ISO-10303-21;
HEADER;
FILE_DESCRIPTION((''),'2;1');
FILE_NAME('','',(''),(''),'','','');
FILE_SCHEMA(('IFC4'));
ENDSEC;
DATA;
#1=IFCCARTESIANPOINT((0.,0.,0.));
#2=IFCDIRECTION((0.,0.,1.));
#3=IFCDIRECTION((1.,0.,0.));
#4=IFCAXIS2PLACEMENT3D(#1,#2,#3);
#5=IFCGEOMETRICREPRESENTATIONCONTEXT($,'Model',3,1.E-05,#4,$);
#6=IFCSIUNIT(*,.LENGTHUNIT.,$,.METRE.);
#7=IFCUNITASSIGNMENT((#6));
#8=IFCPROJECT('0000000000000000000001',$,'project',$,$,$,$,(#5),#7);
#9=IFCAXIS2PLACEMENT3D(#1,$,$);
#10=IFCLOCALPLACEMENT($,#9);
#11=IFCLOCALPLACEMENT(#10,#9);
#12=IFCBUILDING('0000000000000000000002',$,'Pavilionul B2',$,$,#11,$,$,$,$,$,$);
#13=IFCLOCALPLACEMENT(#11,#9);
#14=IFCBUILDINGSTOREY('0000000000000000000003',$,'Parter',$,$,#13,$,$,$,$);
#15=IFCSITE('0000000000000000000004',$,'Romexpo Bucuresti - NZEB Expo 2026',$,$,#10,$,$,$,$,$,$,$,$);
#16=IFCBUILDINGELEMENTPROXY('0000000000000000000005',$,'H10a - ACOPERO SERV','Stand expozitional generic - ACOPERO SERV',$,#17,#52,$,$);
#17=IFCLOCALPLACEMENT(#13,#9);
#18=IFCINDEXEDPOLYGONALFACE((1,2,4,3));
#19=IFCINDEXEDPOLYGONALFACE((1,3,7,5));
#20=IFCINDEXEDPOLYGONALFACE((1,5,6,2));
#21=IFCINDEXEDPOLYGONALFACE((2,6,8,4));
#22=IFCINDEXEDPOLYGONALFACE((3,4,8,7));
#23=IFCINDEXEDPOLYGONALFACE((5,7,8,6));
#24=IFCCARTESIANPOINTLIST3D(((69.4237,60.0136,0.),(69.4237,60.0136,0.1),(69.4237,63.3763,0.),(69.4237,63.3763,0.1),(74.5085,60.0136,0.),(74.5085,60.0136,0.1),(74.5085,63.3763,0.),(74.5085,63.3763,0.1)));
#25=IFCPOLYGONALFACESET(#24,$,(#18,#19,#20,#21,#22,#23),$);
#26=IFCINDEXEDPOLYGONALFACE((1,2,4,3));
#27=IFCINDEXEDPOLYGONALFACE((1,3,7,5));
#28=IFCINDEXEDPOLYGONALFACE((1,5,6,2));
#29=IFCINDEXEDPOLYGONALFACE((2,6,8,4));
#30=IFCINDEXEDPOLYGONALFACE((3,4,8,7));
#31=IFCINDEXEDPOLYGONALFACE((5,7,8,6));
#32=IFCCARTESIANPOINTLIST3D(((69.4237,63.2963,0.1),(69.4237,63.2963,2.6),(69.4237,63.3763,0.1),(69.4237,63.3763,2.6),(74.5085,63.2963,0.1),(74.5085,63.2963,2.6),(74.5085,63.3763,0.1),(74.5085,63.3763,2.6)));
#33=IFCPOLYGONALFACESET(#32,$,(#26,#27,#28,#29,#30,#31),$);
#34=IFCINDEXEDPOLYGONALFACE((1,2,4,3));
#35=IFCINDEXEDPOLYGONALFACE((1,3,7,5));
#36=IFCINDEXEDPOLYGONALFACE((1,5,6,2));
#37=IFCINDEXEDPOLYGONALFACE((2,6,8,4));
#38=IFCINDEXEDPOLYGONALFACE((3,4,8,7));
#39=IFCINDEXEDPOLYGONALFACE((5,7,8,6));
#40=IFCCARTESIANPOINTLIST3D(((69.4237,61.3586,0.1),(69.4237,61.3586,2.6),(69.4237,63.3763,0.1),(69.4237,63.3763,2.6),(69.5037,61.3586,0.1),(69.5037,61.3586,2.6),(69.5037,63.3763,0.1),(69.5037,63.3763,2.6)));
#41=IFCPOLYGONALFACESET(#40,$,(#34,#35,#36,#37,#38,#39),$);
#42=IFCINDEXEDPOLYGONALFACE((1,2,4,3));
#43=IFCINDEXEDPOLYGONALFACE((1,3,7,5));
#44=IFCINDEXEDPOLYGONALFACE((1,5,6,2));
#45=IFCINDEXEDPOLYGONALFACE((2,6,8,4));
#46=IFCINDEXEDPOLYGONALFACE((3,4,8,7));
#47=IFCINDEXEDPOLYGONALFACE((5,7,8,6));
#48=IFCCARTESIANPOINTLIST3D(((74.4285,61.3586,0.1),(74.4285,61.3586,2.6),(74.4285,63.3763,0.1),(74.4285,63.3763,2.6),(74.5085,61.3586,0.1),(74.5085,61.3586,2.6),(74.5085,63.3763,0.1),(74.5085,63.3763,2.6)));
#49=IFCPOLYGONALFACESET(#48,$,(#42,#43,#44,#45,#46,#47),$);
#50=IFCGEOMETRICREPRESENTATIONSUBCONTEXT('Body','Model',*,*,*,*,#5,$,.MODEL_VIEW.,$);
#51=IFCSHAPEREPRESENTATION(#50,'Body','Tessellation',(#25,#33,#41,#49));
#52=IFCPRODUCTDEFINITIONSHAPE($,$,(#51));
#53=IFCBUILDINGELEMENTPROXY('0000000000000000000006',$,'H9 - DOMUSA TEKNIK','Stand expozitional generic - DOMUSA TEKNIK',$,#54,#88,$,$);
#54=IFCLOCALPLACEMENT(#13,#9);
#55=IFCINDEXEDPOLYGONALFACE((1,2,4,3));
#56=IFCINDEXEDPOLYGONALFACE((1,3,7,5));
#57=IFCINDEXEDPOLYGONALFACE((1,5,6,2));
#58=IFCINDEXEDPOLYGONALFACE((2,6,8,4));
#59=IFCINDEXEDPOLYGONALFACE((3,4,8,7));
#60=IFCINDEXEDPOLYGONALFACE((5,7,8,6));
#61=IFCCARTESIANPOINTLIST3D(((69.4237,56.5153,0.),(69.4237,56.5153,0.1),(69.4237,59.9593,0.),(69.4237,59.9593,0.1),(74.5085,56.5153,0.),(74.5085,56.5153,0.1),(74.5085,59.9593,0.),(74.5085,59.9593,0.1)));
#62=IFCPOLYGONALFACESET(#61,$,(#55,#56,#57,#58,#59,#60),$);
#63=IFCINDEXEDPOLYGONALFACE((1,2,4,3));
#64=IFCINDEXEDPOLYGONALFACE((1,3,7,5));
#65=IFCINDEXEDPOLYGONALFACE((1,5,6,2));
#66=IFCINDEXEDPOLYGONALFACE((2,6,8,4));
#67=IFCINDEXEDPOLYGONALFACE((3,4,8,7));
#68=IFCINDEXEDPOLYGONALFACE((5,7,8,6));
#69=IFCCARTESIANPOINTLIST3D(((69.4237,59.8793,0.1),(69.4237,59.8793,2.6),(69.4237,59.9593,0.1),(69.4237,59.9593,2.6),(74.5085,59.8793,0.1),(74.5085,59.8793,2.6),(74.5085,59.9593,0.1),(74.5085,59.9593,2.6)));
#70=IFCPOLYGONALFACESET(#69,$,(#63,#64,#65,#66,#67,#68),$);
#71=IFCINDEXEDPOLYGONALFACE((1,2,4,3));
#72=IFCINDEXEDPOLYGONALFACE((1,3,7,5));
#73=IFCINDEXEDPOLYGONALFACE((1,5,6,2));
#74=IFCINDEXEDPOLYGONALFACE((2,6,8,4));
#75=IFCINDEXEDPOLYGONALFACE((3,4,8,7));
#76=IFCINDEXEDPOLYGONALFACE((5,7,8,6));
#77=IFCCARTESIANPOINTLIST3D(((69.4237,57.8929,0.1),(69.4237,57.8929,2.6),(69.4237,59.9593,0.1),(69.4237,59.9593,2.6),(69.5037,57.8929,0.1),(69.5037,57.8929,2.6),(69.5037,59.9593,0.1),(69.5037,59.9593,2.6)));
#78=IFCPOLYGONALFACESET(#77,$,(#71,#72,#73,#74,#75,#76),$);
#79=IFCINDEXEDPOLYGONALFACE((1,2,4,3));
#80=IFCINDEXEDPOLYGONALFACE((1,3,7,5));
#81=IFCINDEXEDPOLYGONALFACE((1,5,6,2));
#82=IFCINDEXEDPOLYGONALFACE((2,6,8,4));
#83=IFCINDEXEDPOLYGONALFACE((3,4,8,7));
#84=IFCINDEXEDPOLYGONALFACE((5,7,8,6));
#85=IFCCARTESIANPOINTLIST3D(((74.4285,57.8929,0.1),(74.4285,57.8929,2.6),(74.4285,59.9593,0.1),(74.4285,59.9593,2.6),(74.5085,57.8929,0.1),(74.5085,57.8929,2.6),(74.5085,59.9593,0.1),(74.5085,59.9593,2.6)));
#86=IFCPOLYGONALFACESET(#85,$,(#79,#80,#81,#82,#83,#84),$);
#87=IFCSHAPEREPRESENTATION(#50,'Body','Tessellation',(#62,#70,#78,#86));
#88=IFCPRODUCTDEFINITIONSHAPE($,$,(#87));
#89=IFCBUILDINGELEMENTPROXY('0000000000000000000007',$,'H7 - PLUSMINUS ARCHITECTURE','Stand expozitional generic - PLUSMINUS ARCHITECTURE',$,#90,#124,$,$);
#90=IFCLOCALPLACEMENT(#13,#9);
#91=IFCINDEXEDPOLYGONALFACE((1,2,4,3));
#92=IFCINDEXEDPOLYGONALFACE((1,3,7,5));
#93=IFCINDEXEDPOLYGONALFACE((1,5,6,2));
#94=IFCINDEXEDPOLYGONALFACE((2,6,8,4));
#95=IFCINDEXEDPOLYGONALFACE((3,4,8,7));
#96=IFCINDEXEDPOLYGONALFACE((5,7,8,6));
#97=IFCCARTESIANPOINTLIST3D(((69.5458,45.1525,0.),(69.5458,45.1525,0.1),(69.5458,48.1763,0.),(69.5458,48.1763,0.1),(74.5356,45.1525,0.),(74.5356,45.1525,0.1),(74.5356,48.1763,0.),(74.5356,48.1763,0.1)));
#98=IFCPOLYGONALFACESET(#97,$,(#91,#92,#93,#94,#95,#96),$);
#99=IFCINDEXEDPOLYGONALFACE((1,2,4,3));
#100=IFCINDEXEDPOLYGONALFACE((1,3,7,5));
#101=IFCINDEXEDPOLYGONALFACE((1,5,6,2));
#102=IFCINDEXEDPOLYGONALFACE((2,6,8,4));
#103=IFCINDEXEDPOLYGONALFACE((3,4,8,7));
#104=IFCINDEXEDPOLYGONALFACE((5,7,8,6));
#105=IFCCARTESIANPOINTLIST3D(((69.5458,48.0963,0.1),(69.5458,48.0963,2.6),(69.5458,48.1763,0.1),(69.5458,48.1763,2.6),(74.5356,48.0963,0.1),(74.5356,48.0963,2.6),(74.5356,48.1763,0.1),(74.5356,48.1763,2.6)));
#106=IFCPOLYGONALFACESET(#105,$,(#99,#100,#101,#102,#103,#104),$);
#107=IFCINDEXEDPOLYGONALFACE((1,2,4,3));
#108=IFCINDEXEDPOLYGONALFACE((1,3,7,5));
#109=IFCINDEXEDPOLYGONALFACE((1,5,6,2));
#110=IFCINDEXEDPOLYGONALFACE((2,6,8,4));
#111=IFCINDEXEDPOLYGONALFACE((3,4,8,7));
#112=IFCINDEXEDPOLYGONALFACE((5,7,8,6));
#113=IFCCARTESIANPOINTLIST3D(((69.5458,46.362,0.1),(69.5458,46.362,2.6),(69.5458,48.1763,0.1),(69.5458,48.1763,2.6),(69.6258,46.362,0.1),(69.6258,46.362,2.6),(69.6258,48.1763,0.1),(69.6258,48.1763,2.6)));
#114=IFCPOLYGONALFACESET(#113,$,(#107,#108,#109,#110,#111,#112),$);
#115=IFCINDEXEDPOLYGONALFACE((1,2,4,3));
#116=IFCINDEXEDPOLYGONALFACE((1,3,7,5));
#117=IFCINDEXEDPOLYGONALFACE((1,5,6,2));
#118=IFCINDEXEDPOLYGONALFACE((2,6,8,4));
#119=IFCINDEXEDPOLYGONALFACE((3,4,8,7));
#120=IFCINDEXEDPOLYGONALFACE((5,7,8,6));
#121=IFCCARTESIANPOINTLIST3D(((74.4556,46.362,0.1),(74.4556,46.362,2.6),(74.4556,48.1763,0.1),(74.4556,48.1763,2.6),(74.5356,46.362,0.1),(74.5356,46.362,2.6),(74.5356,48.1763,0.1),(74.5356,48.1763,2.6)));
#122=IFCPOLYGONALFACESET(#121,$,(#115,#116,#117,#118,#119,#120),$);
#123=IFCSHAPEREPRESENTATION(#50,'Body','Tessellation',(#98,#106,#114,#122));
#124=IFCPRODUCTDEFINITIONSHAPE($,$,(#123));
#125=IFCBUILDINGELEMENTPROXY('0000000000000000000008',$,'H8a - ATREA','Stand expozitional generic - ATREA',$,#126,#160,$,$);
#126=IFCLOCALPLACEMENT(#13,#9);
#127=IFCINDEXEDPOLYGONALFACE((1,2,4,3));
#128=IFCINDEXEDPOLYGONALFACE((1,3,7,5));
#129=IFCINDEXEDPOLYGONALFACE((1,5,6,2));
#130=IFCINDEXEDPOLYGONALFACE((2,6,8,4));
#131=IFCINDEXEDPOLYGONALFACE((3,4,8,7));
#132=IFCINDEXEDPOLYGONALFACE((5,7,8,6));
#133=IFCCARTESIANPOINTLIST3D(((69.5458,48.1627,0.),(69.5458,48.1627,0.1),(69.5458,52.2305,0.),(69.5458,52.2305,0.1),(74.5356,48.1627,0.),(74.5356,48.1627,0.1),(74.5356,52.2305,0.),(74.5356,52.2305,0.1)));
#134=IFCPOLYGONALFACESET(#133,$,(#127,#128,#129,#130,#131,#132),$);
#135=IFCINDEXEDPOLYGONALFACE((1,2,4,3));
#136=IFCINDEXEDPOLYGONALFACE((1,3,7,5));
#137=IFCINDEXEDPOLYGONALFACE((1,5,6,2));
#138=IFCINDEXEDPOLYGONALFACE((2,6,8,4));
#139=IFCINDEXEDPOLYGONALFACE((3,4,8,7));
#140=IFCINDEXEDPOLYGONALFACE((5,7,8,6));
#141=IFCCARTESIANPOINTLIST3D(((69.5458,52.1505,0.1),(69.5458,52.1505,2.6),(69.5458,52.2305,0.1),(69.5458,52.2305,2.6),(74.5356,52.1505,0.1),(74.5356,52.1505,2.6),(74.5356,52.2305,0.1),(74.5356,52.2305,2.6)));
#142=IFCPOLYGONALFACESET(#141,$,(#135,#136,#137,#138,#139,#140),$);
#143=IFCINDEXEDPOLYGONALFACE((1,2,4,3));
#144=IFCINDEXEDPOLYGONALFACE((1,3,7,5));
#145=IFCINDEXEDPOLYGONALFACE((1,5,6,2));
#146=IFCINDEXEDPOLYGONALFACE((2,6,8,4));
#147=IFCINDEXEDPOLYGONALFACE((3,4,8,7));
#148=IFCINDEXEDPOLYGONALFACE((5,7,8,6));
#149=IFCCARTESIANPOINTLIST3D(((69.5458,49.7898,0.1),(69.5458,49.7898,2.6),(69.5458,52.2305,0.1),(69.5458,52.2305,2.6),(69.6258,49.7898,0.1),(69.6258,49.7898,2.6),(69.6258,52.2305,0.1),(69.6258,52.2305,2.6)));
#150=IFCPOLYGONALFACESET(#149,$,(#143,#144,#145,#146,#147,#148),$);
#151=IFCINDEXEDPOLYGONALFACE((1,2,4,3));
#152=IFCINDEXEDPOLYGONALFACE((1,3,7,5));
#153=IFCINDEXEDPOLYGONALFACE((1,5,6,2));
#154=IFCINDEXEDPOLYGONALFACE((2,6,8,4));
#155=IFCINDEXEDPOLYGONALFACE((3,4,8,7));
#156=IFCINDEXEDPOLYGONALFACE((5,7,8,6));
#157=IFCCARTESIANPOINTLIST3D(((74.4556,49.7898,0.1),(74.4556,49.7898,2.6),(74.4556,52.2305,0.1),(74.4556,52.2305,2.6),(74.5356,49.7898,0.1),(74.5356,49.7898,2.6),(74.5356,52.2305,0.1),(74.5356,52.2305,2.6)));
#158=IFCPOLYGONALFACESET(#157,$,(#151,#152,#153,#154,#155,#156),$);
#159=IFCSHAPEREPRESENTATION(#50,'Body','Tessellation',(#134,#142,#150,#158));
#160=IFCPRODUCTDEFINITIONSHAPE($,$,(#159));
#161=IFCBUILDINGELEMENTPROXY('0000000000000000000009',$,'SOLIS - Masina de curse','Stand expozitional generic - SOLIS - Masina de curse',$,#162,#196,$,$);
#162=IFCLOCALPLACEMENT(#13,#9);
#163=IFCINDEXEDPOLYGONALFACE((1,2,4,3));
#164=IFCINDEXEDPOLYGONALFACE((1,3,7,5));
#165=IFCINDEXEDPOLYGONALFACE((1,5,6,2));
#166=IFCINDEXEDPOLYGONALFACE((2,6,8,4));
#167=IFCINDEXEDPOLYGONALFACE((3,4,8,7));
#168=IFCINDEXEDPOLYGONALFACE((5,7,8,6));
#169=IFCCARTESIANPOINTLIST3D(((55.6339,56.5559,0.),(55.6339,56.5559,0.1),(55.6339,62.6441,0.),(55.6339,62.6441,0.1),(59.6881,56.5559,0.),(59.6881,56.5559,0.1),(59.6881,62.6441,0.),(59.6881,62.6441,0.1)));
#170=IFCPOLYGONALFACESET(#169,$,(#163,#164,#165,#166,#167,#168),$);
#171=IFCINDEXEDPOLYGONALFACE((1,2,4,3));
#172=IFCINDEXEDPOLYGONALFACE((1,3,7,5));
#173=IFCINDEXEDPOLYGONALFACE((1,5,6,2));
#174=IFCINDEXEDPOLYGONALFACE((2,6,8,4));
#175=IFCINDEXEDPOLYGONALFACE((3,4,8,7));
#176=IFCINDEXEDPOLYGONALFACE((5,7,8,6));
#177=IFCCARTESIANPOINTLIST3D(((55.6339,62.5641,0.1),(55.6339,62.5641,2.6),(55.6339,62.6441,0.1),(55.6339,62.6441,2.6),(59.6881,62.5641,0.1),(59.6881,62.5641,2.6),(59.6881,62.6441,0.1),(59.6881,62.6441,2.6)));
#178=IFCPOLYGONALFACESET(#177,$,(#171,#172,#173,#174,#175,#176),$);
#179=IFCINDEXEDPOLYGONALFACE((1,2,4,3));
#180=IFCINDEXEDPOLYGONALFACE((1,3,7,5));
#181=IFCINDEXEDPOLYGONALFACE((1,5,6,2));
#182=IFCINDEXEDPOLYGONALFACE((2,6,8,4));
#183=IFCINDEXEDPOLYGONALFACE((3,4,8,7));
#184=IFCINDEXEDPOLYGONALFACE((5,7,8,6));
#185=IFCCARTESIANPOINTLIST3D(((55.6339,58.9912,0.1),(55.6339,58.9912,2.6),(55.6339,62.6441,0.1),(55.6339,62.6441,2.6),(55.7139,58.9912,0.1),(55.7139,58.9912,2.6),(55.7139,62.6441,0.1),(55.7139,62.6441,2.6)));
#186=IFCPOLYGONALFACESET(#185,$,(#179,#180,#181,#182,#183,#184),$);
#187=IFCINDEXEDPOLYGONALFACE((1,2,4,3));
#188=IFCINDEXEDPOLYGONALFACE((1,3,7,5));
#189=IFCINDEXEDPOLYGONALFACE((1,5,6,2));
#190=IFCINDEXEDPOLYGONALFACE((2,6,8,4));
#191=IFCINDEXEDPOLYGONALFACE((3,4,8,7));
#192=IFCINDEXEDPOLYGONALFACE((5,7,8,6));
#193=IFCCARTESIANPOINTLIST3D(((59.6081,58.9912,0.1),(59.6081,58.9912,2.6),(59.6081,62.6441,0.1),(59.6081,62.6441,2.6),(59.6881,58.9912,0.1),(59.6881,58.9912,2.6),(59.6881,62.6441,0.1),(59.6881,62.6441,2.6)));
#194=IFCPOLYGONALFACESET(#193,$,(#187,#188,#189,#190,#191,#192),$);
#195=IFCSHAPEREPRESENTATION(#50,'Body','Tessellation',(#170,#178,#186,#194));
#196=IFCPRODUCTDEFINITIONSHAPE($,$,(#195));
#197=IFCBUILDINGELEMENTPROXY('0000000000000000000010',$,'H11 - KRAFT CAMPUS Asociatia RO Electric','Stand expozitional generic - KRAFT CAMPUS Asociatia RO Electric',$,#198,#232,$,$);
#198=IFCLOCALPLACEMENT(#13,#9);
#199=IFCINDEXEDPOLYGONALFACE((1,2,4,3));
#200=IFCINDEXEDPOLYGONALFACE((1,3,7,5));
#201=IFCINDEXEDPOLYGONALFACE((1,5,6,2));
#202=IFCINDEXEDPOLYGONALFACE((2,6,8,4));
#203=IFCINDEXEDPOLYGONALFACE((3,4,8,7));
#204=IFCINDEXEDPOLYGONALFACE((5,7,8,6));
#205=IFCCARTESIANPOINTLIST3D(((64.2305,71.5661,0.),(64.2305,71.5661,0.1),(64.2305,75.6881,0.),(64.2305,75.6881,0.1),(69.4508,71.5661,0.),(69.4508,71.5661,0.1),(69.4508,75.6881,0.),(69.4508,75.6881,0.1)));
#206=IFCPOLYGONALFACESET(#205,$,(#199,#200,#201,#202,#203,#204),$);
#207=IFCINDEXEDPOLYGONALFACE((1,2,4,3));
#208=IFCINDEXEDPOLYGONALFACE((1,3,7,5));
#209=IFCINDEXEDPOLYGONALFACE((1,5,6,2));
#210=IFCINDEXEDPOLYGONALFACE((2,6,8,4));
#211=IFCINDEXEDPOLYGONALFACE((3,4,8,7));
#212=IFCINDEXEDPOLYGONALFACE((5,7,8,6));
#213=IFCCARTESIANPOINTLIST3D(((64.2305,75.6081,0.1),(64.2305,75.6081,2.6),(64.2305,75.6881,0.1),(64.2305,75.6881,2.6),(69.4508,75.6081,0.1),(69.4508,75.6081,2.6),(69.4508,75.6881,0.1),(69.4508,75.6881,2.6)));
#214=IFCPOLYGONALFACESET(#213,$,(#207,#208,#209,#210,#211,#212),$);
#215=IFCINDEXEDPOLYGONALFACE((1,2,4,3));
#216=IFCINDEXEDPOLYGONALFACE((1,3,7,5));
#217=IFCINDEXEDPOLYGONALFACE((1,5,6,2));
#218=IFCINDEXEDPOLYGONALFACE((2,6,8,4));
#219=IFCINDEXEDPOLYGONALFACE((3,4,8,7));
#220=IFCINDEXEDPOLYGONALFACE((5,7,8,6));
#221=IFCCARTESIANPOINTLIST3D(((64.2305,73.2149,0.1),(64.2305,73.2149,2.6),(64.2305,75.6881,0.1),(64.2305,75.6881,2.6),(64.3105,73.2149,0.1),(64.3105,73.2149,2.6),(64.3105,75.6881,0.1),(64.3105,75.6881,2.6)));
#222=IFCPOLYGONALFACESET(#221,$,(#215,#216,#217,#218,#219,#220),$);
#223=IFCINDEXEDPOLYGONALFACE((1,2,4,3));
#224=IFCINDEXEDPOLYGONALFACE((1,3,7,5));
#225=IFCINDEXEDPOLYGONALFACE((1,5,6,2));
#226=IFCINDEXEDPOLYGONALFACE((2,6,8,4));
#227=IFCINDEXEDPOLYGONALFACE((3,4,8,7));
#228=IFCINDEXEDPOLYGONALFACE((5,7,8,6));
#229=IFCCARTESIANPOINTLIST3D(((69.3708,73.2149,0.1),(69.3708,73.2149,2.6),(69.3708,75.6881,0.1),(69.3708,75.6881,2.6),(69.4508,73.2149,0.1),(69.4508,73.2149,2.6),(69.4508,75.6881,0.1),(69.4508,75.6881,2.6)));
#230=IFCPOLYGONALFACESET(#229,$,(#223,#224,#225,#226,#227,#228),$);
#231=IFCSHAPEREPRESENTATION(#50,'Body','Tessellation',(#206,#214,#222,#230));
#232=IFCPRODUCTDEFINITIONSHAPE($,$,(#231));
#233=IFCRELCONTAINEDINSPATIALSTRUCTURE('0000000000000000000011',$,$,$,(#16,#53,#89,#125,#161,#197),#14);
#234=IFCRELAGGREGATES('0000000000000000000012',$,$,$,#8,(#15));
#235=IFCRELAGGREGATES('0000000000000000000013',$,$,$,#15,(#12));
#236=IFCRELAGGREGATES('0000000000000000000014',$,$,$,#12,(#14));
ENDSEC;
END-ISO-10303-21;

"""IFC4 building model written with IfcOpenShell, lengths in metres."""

from ifc_helpers import new_model, si_unit, frame, frame_2d, origin, origin_with_axes, place, context, subcontext, project, spatial, rectangle, extrude, element, save


model = new_model("IFC4")

# Units and contexts
model_context = context("Model", 3, precision=1e-05, world=origin_with_axes())
body_context = subcontext(model_context, "Body", "Model", "MODEL_VIEW")
ifc_project = project(units=[si_unit("LENGTHUNIT", "METRE")], contexts=[model_context])

# Site, building, storey
site_placement = place(None, origin())
site = spatial("IfcSite", under=ifc_project, at=site_placement, Name="Romexpo Bucuresti - NZEB Expo 2026")
building_placement = place(site_placement, origin())
building = spatial("IfcBuilding", under=site, at=building_placement, Name="Pavilionul B2")
storey_placement = place(building_placement, origin())
storey = spatial("IfcBuildingStorey", under=building, at=storey_placement, Name="Parter")

# Building element proxies
proxy_1_placement = place(storey_placement, frame((69.4237, 60.0136, 0.0), z_axis=(0.0, 0.0, 1.0), x_axis=(1.0, 0.0, 0.0)))
element("IfcBuildingElementProxy", 1, at=proxy_1_placement, inside=storey, Name="H10a - ACOPERO SERV", Description="Stand expozitional generic - ACOPERO SERV", context=body_context, shape_type="SweptSolid", body=[
    extrude(rectangle(XDim=5.0847, YDim=3.3627, at=frame_2d((2.5424, 1.6814))), origin(), (0.0, 0.0, 1.0), 0.1),
    extrude(rectangle(XDim=5.0847, YDim=0.08, at=frame_2d((2.5424, 3.3227))), frame((0.0, 0.0, 0.1)), (0.0, 0.0, 1.0), 2.5),
    extrude(rectangle(XDim=0.08, YDim=2.0176, at=frame_2d((0.04, 2.3539))), frame((0.0, 0.0, 0.1)), (0.0, 0.0, 1.0), 2.5),
    extrude(rectangle(XDim=0.08, YDim=2.0176, at=frame_2d((5.0447, 2.3539))), frame((0.0, 0.0, 0.1)), (0.0, 0.0, 1.0), 2.5),
])
proxy_2_placement = place(storey_placement, frame((69.4237, 56.5153, 0.0), z_axis=(0.0, 0.0, 1.0), x_axis=(1.0, 0.0, 0.0)))
element("IfcBuildingElementProxy", 2, at=proxy_2_placement, inside=storey, Name="H9 - DOMUSA TEKNIK", Description="Stand expozitional generic - DOMUSA TEKNIK", context=body_context, shape_type="SweptSolid", body=[
    extrude(rectangle(XDim=5.0847, YDim=3.4441, at=frame_2d((2.5424, 1.722))), origin(), (0.0, 0.0, 1.0), 0.1),
    extrude(rectangle(XDim=5.0847, YDim=0.08, at=frame_2d((2.5424, 3.4041))), frame((0.0, 0.0, 0.1)), (0.0, 0.0, 1.0), 2.5),
    extrude(rectangle(XDim=0.08, YDim=2.0664, at=frame_2d((0.04, 2.4108))), frame((0.0, 0.0, 0.1)), (0.0, 0.0, 1.0), 2.5),
    extrude(rectangle(XDim=0.08, YDim=2.0664, at=frame_2d((5.0447, 2.4108))), frame((0.0, 0.0, 0.1)), (0.0, 0.0, 1.0), 2.5),
])
proxy_3_placement = place(storey_placement, frame((69.5458, 45.1525, 0.0), z_axis=(0.0, 0.0, 1.0), x_axis=(1.0, 0.0, 0.0)))
element("IfcBuildingElementProxy", 3, at=proxy_3_placement, inside=storey, Name="H7 - PLUSMINUS ARCHITECTURE", Description="Stand expozitional generic - PLUSMINUS ARCHITECTURE", context=body_context, shape_type="SweptSolid", body=[
    extrude(rectangle(XDim=4.9898, YDim=3.0237, at=frame_2d((2.4949, 1.5119))), origin(), (0.0, 0.0, 1.0), 0.1),
    extrude(rectangle(XDim=4.9898, YDim=0.08, at=frame_2d((2.4949, 2.9837))), frame((0.0, 0.0, 0.1)), (0.0, 0.0, 1.0), 2.5),
    extrude(rectangle(XDim=0.08, YDim=1.8142, at=frame_2d((0.04, 2.1166))), frame((0.0, 0.0, 0.1)), (0.0, 0.0, 1.0), 2.5),
    extrude(rectangle(XDim=0.08, YDim=1.8142, at=frame_2d((4.9498, 2.1166))), frame((0.0, 0.0, 0.1)), (0.0, 0.0, 1.0), 2.5),
])
proxy_4_placement = place(storey_placement, frame((69.5458, 48.1627, 0.0), z_axis=(0.0, 0.0, 1.0), x_axis=(1.0, 0.0, 0.0)))
element("IfcBuildingElementProxy", 4, at=proxy_4_placement, inside=storey, Name="H8a - ATREA", Description="Stand expozitional generic - ATREA", context=body_context, shape_type="SweptSolid", body=[
    extrude(rectangle(XDim=4.9898, YDim=4.0678, at=frame_2d((2.4949, 2.0339))), origin(), (0.0, 0.0, 1.0), 0.1),
    extrude(rectangle(XDim=4.9898, YDim=0.08, at=frame_2d((2.4949, 4.0278))), frame((0.0, 0.0, 0.1)), (0.0, 0.0, 1.0), 2.5),
    extrude(rectangle(XDim=0.08, YDim=2.4407, at=frame_2d((0.04, 2.8475))), frame((0.0, 0.0, 0.1)), (0.0, 0.0, 1.0), 2.5),
    extrude(rectangle(XDim=0.08, YDim=2.4407, at=frame_2d((4.9498, 2.8475))), frame((0.0, 0.0, 0.1)), (0.0, 0.0, 1.0), 2.5),
])
proxy_5_placement = place(storey_placement, frame((55.6339, 56.5559, 0.0), z_axis=(0.0, 0.0, 1.0), x_axis=(1.0, 0.0, 0.0)))
element("IfcBuildingElementProxy", 5, at=proxy_5_placement, inside=storey, Name="SOLIS - Masina de curse", Description="Stand expozitional generic - SOLIS - Masina de curse", context=body_context, shape_type="SweptSolid", body=[
    extrude(rectangle(XDim=4.0542, YDim=6.0881, at=frame_2d((2.0271, 3.0441))), origin(), (0.0, 0.0, 1.0), 0.1),
    extrude(rectangle(XDim=4.0542, YDim=0.08, at=frame_2d((2.0271, 6.0481))), frame((0.0, 0.0, 0.1)), (0.0, 0.0, 1.0), 2.5),
    extrude(rectangle(XDim=0.08, YDim=3.6529, at=frame_2d((0.04, 4.2617))), frame((0.0, 0.0, 0.1)), (0.0, 0.0, 1.0), 2.5),
    extrude(rectangle(XDim=0.08, YDim=3.6529, at=frame_2d((4.0142, 4.2617))), frame((0.0, 0.0, 0.1)), (0.0, 0.0, 1.0), 2.5),
])
proxy_6_placement = place(storey_placement, frame((64.2305, 71.5661, 0.0), z_axis=(0.0, 0.0, 1.0), x_axis=(1.0, 0.0, 0.0)))
element("IfcBuildingElementProxy", 6, at=proxy_6_placement, inside=storey, Name="H11 - KRAFT CAMPUS Asociatia RO Electric", Description="Stand expozitional generic - KRAFT CAMPUS Asociatia RO Electric", context=body_context, shape_type="SweptSolid", body=[
    extrude(rectangle(XDim=5.2203, YDim=4.122, at=frame_2d((2.6102, 2.061))), origin(), (0.0, 0.0, 1.0), 0.1),
    extrude(rectangle(XDim=5.2203, YDim=0.08, at=frame_2d((2.6102, 4.082))), frame((0.0, 0.0, 0.1)), (0.0, 0.0, 1.0), 2.5),
    extrude(rectangle(XDim=0.08, YDim=2.4732, at=frame_2d((0.04, 2.8854))), frame((0.0, 0.0, 0.1)), (0.0, 0.0, 1.0), 2.5),
    extrude(rectangle(XDim=0.08, YDim=2.4732, at=frame_2d((5.1803, 2.8854))), frame((0.0, 0.0, 0.1)), (0.0, 0.0, 1.0), 2.5),
])

save(model, "model.ifc")
